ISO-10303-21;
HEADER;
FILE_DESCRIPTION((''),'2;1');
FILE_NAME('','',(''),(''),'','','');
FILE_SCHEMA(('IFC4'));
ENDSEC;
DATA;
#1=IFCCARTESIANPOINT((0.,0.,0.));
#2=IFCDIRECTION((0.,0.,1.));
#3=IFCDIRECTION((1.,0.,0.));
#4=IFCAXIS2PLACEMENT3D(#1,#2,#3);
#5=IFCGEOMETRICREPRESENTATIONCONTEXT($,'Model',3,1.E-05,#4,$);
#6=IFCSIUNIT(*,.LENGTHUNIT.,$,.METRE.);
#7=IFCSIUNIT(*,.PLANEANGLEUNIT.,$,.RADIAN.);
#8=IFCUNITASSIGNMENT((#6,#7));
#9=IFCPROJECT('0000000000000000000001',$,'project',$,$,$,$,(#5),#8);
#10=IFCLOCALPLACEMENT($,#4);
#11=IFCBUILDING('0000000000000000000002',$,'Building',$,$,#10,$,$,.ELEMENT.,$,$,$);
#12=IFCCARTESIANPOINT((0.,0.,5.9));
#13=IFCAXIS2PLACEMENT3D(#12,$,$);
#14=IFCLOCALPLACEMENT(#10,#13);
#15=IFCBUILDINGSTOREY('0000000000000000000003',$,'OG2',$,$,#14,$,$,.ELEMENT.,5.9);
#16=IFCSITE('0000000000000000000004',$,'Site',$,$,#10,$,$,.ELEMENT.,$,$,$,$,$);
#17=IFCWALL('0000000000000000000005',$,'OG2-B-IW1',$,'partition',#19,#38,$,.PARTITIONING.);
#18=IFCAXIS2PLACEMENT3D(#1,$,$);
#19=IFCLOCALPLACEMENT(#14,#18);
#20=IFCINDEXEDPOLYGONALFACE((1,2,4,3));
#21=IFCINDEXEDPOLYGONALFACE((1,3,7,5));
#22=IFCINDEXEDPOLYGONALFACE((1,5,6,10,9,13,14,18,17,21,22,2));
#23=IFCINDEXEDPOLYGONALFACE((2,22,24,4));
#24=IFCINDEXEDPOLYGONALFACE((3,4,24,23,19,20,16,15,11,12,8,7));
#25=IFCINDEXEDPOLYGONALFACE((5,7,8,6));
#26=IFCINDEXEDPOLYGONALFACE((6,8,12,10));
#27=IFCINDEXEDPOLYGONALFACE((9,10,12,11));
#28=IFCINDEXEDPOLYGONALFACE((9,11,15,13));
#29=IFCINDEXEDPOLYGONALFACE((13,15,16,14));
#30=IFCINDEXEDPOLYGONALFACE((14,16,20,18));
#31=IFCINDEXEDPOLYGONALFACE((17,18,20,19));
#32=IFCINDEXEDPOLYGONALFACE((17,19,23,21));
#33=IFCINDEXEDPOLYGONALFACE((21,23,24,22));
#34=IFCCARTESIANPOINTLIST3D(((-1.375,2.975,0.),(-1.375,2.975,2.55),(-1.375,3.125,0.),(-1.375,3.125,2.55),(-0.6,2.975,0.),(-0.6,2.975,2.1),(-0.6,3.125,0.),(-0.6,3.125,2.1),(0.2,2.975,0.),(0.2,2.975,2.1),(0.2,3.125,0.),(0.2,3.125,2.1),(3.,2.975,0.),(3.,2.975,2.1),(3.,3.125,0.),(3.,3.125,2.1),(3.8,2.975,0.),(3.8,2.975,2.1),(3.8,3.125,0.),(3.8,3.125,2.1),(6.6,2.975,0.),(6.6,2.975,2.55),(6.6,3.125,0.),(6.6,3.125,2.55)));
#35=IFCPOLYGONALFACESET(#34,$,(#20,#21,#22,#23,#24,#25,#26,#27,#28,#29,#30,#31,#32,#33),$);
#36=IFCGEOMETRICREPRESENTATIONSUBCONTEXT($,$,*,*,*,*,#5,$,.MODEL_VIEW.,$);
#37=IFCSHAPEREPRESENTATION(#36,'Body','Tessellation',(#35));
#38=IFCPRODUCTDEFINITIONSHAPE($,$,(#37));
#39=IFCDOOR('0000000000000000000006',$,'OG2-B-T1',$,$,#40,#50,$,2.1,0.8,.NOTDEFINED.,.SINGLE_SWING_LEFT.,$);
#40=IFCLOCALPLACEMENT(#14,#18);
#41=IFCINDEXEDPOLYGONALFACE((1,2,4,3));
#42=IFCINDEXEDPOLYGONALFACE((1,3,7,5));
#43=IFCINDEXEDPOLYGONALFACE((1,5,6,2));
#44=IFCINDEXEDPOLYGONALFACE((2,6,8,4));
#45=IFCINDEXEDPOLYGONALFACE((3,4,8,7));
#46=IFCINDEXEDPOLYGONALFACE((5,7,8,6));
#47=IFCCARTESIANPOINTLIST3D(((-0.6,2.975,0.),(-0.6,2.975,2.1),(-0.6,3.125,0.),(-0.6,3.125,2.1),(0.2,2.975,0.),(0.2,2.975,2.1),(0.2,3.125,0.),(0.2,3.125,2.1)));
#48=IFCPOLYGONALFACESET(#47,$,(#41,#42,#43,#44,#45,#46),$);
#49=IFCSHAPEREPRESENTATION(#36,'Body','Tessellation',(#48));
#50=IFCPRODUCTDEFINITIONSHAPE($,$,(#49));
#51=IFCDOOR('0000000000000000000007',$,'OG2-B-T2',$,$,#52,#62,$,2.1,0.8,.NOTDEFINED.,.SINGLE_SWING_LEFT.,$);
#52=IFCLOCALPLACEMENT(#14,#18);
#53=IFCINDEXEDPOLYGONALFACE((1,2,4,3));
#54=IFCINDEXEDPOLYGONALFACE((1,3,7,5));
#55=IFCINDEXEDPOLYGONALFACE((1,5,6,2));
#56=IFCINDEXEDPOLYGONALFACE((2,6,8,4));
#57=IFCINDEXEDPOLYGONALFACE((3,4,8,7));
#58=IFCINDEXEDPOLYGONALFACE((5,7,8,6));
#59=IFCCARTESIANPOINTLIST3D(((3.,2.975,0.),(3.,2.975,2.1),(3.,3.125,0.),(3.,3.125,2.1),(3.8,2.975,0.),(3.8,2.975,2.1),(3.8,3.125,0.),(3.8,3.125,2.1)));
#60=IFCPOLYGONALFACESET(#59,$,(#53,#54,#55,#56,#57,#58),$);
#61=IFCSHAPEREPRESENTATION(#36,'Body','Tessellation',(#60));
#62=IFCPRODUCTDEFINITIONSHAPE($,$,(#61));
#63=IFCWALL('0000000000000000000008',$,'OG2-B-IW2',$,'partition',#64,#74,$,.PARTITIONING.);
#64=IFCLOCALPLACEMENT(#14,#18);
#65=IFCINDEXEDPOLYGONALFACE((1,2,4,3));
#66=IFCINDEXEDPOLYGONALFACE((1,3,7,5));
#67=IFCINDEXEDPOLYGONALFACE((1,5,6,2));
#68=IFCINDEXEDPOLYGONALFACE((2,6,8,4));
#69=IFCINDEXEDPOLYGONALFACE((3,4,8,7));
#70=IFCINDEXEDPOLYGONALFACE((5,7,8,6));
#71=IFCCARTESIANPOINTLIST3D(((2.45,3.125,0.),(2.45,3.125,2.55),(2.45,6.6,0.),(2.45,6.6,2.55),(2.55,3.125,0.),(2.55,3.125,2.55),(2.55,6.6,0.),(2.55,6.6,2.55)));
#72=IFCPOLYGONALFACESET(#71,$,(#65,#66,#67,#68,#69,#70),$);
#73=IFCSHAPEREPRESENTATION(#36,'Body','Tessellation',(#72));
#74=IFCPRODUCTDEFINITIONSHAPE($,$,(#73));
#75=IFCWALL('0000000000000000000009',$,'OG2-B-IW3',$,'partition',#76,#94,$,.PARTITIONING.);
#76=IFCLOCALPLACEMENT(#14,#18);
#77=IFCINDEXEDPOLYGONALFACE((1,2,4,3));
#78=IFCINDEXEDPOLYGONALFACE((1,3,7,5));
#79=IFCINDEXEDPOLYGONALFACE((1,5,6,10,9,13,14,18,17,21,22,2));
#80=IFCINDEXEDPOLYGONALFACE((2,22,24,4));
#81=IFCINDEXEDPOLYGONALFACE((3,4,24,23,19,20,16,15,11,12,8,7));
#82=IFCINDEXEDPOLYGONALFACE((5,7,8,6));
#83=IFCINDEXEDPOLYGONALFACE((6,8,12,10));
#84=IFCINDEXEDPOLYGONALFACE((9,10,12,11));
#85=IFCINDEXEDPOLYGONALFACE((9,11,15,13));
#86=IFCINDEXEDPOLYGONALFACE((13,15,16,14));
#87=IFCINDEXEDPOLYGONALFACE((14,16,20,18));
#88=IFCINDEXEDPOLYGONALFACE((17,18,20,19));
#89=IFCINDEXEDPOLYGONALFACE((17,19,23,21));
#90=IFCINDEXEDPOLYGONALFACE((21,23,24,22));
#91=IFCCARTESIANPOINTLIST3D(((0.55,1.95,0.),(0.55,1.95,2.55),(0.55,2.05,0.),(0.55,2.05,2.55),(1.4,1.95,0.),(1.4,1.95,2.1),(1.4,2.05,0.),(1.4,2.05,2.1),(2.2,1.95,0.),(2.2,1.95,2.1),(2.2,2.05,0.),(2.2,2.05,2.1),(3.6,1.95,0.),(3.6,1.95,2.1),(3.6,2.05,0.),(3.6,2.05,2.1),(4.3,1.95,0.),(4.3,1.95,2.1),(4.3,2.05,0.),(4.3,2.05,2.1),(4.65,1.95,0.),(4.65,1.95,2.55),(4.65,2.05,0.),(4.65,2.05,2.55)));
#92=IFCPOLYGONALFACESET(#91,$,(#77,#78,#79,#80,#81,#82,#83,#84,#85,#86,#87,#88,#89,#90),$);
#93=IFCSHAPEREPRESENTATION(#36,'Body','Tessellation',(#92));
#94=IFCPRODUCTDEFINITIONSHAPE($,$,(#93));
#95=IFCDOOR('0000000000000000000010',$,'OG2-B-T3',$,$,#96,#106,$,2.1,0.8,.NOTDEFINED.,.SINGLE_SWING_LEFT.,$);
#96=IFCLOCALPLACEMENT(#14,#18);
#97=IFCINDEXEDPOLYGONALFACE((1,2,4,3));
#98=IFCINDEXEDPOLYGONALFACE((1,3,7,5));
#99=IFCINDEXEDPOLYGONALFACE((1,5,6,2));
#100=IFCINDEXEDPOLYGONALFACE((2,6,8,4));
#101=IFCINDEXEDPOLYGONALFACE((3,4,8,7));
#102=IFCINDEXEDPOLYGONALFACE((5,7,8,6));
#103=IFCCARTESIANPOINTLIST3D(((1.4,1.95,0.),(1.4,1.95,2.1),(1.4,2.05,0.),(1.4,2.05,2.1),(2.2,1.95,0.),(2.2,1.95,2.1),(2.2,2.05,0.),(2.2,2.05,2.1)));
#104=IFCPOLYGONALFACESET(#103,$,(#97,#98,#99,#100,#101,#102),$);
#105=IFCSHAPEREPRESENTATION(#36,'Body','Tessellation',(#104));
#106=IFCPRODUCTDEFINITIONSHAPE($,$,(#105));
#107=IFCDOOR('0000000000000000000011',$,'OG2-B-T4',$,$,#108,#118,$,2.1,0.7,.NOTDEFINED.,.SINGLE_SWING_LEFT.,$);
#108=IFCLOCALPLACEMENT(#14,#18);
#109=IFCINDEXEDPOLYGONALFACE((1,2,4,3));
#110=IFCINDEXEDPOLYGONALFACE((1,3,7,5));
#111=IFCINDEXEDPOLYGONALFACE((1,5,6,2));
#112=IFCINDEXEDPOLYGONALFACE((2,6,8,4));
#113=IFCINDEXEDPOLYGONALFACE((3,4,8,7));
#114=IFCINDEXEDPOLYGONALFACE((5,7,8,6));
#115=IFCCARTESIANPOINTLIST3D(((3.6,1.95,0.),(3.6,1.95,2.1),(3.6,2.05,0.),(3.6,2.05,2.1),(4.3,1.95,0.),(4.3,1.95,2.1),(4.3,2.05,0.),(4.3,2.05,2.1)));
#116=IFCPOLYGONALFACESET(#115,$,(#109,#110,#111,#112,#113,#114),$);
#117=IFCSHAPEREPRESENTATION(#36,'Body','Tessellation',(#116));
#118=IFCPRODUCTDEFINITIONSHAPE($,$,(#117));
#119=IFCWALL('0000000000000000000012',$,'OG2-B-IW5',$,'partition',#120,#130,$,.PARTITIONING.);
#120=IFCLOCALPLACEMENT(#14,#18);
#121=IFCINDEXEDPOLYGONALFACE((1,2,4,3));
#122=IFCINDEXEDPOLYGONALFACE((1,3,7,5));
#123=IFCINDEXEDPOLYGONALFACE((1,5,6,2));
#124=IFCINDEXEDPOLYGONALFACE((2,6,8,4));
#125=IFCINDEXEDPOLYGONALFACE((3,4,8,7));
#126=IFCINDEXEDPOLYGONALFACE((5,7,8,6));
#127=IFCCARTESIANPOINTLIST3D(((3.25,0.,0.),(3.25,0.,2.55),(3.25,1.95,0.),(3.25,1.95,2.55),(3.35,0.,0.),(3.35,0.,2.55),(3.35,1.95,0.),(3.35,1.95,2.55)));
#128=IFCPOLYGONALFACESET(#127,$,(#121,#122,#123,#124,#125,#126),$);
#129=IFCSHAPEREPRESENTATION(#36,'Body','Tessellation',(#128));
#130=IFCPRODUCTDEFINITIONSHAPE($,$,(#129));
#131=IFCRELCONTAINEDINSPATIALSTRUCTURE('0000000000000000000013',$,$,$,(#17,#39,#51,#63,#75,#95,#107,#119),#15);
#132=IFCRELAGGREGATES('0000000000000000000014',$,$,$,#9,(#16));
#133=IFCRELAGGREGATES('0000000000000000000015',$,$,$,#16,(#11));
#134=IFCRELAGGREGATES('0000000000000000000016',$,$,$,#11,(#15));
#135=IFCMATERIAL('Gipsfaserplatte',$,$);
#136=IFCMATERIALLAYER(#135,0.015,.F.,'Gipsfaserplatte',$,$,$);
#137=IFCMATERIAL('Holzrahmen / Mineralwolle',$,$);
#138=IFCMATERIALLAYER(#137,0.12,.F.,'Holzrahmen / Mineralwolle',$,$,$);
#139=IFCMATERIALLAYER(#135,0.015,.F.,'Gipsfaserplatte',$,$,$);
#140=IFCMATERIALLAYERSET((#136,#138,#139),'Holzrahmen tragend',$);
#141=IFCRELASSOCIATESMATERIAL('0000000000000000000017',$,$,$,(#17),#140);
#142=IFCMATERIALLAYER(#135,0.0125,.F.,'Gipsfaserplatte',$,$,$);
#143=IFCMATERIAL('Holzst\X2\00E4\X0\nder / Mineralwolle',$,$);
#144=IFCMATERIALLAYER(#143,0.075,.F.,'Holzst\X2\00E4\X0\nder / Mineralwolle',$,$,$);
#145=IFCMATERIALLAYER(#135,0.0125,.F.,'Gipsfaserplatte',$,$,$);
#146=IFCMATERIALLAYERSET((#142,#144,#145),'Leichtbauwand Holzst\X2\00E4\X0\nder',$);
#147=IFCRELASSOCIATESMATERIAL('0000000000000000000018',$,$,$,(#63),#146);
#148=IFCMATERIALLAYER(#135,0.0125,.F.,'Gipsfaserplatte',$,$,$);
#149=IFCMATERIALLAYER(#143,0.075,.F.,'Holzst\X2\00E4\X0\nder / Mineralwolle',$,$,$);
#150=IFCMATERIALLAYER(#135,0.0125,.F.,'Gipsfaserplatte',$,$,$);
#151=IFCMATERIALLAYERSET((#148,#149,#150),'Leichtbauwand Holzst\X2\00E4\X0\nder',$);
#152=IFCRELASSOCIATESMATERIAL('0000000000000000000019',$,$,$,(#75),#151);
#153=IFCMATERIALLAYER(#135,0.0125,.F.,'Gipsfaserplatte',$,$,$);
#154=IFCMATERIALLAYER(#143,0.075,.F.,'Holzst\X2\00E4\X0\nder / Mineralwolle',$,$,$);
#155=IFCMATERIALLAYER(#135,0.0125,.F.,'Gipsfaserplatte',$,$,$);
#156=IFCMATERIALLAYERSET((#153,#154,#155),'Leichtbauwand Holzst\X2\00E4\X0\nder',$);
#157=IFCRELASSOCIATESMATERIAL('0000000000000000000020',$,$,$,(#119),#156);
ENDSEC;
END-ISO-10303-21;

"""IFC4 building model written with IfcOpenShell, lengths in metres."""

from ifc_helpers import new_model, si_unit, frame, frame_2d, origin, origin_with_axes, place, context, subcontext, project, spatial, rectangle, extrude, material, layer, layer_set, element, fill, save


model = new_model("IFC4")

# Units and contexts
model_context = context("Model", 3, precision=1e-05, world=origin_with_axes())
sub_context = subcontext(model_context, None, None, "MODEL_VIEW")
ifc_project = project(units=[si_unit("LENGTHUNIT", "METRE"), si_unit("PLANEANGLEUNIT", "RADIAN")], contexts=[model_context])

# Site, building, storey
placement = place(None, origin_with_axes())
site = spatial("IfcSite", under=ifc_project, at=placement, Name="Site", CompositionType="ELEMENT")
building = spatial("IfcBuilding", under=site, at=placement, Name="Building", CompositionType="ELEMENT")
storey_placement = place(placement, frame((0.0, 0.0, 5.9)))
storey = spatial("IfcBuildingStorey", under=building, at=storey_placement, Name="OG2", CompositionType="ELEMENT", Elevation=5.9)

# Shared definitions
ifc_material_1 = material(Name="Gipsfaserplatte")
ifc_material_2 = material(Name="Holzrahmen / Mineralwolle")

# Wall, openings, doors
ifc_layer_1 = layer(ifc_material_1, 0.015, ventilated=False, Name="Gipsfaserplatte")
ifc_layer_2 = layer(ifc_material_2, 0.12, ventilated=False, Name="Holzrahmen / Mineralwolle")
ifc_layer_3 = layer(ifc_material_1, 0.015, ventilated=False, Name="Gipsfaserplatte")
ifc_layer_set_1 = layer_set([ifc_layer_1, ifc_layer_2, ifc_layer_3], Name="Holzrahmen tragend")
wall_1_placement = place(storey_placement, frame((-1.375, 3.05, 0.0), z_axis=(0.0, 0.0, 1.0), x_axis=(1.0, 0.0, 0.0)))
wall_1 = element("IfcWall", 1, at=wall_1_placement, inside=storey, material=ifc_layer_set_1, Name="OG2-B-IW1", ObjectType="partition", PredefinedType="PARTITIONING", context=sub_context, shape_type="SweptSolid", body=[
    extrude(rectangle(XDim=7.975, YDim=0.15, at=frame_2d((3.9875, 0.0))), origin(), (0.0, 0.0, 1.0), 2.55),
])
opening_1_placement = place(wall_1_placement, frame((1.175, 0.125, 0.0), z_axis=(0.0, -1.0, 0.0), x_axis=(1.0, 0.0, 0.0)))
opening_1 = element("IfcOpeningElement", 2, at=opening_1_placement, cuts=wall_1, PredefinedType="OPENING", context=sub_context, shape_type="SweptSolid", body=[
    extrude(rectangle(XDim=0.8, YDim=2.1, at=frame_2d((0.0, 1.05))), origin(), (0.0, 0.0, 1.0), 0.25),
])
opening_2_placement = place(wall_1_placement, frame((4.775, 0.125, 0.0), z_axis=(0.0, -1.0, 0.0), x_axis=(1.0, 0.0, 0.0)))
opening_2 = element("IfcOpeningElement", 3, at=opening_2_placement, cuts=wall_1, PredefinedType="OPENING", context=sub_context, shape_type="SweptSolid", body=[
    extrude(rectangle(XDim=0.8, YDim=2.1, at=frame_2d((0.0, 1.05))), origin(), (0.0, 0.0, 1.0), 0.25),
])
door_1_placement = place(wall_1_placement, frame((1.175, 0.075, 0.0), z_axis=(0.0, -1.0, 0.0), x_axis=(1.0, 0.0, 0.0)))
door_1 = element("IfcDoor", 4, at=door_1_placement, inside=storey, Name="OG2-B-T1", OperationType="SINGLE_SWING_LEFT", OverallHeight=2.1, OverallWidth=0.8, PredefinedType="NOTDEFINED", context=sub_context, shape_type="SweptSolid", body=[
    extrude(rectangle(XDim=0.8, YDim=2.1, at=frame_2d((0.0, 1.05))), origin(), (0.0, 0.0, 1.0), 0.15),
])
fill(opening_1, door_1)
door_2_placement = place(wall_1_placement, frame((4.775, 0.075, 0.0), z_axis=(0.0, -1.0, 0.0), x_axis=(1.0, 0.0, 0.0)))
door_2 = element("IfcDoor", 5, at=door_2_placement, inside=storey, Name="OG2-B-T2", OperationType="SINGLE_SWING_LEFT", OverallHeight=2.1, OverallWidth=0.8, PredefinedType="NOTDEFINED", context=sub_context, shape_type="SweptSolid", body=[
    extrude(rectangle(XDim=0.8, YDim=2.1, at=frame_2d((0.0, 1.05))), origin(), (0.0, 0.0, 1.0), 0.15),
])
fill(opening_2, door_2)

# Wall
ifc_layer_4 = layer(ifc_material_1, 0.0125, ventilated=False, Name="Gipsfaserplatte")
ifc_material_3 = material(Name="Holzständer / Mineralwolle")
ifc_layer_5 = layer(ifc_material_3, 0.075, ventilated=False, Name="Holzständer / Mineralwolle")
ifc_layer_6 = layer(ifc_material_1, 0.0125, ventilated=False, Name="Gipsfaserplatte")
ifc_layer_set_2 = layer_set([ifc_layer_4, ifc_layer_5, ifc_layer_6], Name="Leichtbauwand Holzständer")
wall_2_placement = place(storey_placement, frame((2.5, 3.125, 0.0), z_axis=(0.0, 0.0, 1.0), x_axis=(0.0, 1.0, 0.0)))
element("IfcWall", 6, at=wall_2_placement, inside=storey, material=ifc_layer_set_2, Name="OG2-B-IW2", ObjectType="partition", PredefinedType="PARTITIONING", context=sub_context, shape_type="SweptSolid", body=[
    extrude(rectangle(XDim=3.475, YDim=0.1, at=frame_2d((1.7375, 0.0))), origin(), (0.0, 0.0, 1.0), 2.55),
])

# Wall, openings, doors
ifc_layer_7 = layer(ifc_material_1, 0.0125, ventilated=False, Name="Gipsfaserplatte")
ifc_layer_8 = layer(ifc_material_3, 0.075, ventilated=False, Name="Holzständer / Mineralwolle")
ifc_layer_9 = layer(ifc_material_1, 0.0125, ventilated=False, Name="Gipsfaserplatte")
ifc_layer_set_3 = layer_set([ifc_layer_7, ifc_layer_8, ifc_layer_9], Name="Leichtbauwand Holzständer")
wall_3_placement = place(storey_placement, frame((0.55, 2.0, 0.0), z_axis=(0.0, 0.0, 1.0), x_axis=(1.0, 0.0, 0.0)))
wall_3 = element("IfcWall", 7, at=wall_3_placement, inside=storey, material=ifc_layer_set_3, Name="OG2-B-IW3", ObjectType="partition", PredefinedType="PARTITIONING", context=sub_context, shape_type="SweptSolid", body=[
    extrude(rectangle(XDim=4.1, YDim=0.1, at=frame_2d((2.05, 0.0))), origin(), (0.0, 0.0, 1.0), 2.55),
])
opening_3_placement = place(wall_3_placement, frame((1.25, 0.1, 0.0), z_axis=(0.0, -1.0, 0.0), x_axis=(1.0, 0.0, 0.0)))
opening_3 = element("IfcOpeningElement", 8, at=opening_3_placement, cuts=wall_3, PredefinedType="OPENING", context=sub_context, shape_type="SweptSolid", body=[
    extrude(rectangle(XDim=0.8, YDim=2.1, at=frame_2d((0.0, 1.05))), origin(), (0.0, 0.0, 1.0), 0.2),
])
opening_4_placement = place(wall_3_placement, frame((3.4, 0.1, 0.0), z_axis=(0.0, -1.0, 0.0), x_axis=(1.0, 0.0, 0.0)))
opening_4 = element("IfcOpeningElement", 9, at=opening_4_placement, cuts=wall_3, PredefinedType="OPENING", context=sub_context, shape_type="SweptSolid", body=[
    extrude(rectangle(XDim=0.7, YDim=2.1, at=frame_2d((0.0, 1.05))), origin(), (0.0, 0.0, 1.0), 0.2),
])
door_3_placement = place(wall_3_placement, frame((1.25, 0.05, 0.0), z_axis=(0.0, -1.0, 0.0), x_axis=(1.0, 0.0, 0.0)))
door_3 = element("IfcDoor", 10, at=door_3_placement, inside=storey, Name="OG2-B-T3", OperationType="SINGLE_SWING_LEFT", OverallHeight=2.1, OverallWidth=0.8, PredefinedType="NOTDEFINED", context=sub_context, shape_type="SweptSolid", body=[
    extrude(rectangle(XDim=0.8, YDim=2.1, at=frame_2d((0.0, 1.05))), origin(), (0.0, 0.0, 1.0), 0.1),
])
fill(opening_3, door_3)
door_4_placement = place(wall_3_placement, frame((3.4, 0.05, 0.0), z_axis=(0.0, -1.0, 0.0), x_axis=(1.0, 0.0, 0.0)))
door_4 = element("IfcDoor", 11, at=door_4_placement, inside=storey, Name="OG2-B-T4", OperationType="SINGLE_SWING_LEFT", OverallHeight=2.1, OverallWidth=0.7, PredefinedType="NOTDEFINED", context=sub_context, shape_type="SweptSolid", body=[
    extrude(rectangle(XDim=0.7, YDim=2.1, at=frame_2d((0.0, 1.05))), origin(), (0.0, 0.0, 1.0), 0.1),
])
fill(opening_4, door_4)

# Wall
ifc_layer_10 = layer(ifc_material_1, 0.0125, ventilated=False, Name="Gipsfaserplatte")
ifc_layer_11 = layer(ifc_material_3, 0.075, ventilated=False, Name="Holzständer / Mineralwolle")
ifc_layer_12 = layer(ifc_material_1, 0.0125, ventilated=False, Name="Gipsfaserplatte")
ifc_layer_set_4 = layer_set([ifc_layer_10, ifc_layer_11, ifc_layer_12], Name="Leichtbauwand Holzständer")
wall_4_placement = place(storey_placement, frame((3.3, 0.0, 0.0), z_axis=(0.0, 0.0, 1.0), x_axis=(0.0, 1.0, 0.0)))
element("IfcWall", 12, at=wall_4_placement, inside=storey, material=ifc_layer_set_4, Name="OG2-B-IW5", ObjectType="partition", PredefinedType="PARTITIONING", context=sub_context, shape_type="SweptSolid", body=[
    extrude(rectangle(XDim=1.95, YDim=0.1, at=frame_2d((0.975, 0.0))), origin(), (0.0, 0.0, 1.0), 2.55),
])

save(model, "model.ifc")
